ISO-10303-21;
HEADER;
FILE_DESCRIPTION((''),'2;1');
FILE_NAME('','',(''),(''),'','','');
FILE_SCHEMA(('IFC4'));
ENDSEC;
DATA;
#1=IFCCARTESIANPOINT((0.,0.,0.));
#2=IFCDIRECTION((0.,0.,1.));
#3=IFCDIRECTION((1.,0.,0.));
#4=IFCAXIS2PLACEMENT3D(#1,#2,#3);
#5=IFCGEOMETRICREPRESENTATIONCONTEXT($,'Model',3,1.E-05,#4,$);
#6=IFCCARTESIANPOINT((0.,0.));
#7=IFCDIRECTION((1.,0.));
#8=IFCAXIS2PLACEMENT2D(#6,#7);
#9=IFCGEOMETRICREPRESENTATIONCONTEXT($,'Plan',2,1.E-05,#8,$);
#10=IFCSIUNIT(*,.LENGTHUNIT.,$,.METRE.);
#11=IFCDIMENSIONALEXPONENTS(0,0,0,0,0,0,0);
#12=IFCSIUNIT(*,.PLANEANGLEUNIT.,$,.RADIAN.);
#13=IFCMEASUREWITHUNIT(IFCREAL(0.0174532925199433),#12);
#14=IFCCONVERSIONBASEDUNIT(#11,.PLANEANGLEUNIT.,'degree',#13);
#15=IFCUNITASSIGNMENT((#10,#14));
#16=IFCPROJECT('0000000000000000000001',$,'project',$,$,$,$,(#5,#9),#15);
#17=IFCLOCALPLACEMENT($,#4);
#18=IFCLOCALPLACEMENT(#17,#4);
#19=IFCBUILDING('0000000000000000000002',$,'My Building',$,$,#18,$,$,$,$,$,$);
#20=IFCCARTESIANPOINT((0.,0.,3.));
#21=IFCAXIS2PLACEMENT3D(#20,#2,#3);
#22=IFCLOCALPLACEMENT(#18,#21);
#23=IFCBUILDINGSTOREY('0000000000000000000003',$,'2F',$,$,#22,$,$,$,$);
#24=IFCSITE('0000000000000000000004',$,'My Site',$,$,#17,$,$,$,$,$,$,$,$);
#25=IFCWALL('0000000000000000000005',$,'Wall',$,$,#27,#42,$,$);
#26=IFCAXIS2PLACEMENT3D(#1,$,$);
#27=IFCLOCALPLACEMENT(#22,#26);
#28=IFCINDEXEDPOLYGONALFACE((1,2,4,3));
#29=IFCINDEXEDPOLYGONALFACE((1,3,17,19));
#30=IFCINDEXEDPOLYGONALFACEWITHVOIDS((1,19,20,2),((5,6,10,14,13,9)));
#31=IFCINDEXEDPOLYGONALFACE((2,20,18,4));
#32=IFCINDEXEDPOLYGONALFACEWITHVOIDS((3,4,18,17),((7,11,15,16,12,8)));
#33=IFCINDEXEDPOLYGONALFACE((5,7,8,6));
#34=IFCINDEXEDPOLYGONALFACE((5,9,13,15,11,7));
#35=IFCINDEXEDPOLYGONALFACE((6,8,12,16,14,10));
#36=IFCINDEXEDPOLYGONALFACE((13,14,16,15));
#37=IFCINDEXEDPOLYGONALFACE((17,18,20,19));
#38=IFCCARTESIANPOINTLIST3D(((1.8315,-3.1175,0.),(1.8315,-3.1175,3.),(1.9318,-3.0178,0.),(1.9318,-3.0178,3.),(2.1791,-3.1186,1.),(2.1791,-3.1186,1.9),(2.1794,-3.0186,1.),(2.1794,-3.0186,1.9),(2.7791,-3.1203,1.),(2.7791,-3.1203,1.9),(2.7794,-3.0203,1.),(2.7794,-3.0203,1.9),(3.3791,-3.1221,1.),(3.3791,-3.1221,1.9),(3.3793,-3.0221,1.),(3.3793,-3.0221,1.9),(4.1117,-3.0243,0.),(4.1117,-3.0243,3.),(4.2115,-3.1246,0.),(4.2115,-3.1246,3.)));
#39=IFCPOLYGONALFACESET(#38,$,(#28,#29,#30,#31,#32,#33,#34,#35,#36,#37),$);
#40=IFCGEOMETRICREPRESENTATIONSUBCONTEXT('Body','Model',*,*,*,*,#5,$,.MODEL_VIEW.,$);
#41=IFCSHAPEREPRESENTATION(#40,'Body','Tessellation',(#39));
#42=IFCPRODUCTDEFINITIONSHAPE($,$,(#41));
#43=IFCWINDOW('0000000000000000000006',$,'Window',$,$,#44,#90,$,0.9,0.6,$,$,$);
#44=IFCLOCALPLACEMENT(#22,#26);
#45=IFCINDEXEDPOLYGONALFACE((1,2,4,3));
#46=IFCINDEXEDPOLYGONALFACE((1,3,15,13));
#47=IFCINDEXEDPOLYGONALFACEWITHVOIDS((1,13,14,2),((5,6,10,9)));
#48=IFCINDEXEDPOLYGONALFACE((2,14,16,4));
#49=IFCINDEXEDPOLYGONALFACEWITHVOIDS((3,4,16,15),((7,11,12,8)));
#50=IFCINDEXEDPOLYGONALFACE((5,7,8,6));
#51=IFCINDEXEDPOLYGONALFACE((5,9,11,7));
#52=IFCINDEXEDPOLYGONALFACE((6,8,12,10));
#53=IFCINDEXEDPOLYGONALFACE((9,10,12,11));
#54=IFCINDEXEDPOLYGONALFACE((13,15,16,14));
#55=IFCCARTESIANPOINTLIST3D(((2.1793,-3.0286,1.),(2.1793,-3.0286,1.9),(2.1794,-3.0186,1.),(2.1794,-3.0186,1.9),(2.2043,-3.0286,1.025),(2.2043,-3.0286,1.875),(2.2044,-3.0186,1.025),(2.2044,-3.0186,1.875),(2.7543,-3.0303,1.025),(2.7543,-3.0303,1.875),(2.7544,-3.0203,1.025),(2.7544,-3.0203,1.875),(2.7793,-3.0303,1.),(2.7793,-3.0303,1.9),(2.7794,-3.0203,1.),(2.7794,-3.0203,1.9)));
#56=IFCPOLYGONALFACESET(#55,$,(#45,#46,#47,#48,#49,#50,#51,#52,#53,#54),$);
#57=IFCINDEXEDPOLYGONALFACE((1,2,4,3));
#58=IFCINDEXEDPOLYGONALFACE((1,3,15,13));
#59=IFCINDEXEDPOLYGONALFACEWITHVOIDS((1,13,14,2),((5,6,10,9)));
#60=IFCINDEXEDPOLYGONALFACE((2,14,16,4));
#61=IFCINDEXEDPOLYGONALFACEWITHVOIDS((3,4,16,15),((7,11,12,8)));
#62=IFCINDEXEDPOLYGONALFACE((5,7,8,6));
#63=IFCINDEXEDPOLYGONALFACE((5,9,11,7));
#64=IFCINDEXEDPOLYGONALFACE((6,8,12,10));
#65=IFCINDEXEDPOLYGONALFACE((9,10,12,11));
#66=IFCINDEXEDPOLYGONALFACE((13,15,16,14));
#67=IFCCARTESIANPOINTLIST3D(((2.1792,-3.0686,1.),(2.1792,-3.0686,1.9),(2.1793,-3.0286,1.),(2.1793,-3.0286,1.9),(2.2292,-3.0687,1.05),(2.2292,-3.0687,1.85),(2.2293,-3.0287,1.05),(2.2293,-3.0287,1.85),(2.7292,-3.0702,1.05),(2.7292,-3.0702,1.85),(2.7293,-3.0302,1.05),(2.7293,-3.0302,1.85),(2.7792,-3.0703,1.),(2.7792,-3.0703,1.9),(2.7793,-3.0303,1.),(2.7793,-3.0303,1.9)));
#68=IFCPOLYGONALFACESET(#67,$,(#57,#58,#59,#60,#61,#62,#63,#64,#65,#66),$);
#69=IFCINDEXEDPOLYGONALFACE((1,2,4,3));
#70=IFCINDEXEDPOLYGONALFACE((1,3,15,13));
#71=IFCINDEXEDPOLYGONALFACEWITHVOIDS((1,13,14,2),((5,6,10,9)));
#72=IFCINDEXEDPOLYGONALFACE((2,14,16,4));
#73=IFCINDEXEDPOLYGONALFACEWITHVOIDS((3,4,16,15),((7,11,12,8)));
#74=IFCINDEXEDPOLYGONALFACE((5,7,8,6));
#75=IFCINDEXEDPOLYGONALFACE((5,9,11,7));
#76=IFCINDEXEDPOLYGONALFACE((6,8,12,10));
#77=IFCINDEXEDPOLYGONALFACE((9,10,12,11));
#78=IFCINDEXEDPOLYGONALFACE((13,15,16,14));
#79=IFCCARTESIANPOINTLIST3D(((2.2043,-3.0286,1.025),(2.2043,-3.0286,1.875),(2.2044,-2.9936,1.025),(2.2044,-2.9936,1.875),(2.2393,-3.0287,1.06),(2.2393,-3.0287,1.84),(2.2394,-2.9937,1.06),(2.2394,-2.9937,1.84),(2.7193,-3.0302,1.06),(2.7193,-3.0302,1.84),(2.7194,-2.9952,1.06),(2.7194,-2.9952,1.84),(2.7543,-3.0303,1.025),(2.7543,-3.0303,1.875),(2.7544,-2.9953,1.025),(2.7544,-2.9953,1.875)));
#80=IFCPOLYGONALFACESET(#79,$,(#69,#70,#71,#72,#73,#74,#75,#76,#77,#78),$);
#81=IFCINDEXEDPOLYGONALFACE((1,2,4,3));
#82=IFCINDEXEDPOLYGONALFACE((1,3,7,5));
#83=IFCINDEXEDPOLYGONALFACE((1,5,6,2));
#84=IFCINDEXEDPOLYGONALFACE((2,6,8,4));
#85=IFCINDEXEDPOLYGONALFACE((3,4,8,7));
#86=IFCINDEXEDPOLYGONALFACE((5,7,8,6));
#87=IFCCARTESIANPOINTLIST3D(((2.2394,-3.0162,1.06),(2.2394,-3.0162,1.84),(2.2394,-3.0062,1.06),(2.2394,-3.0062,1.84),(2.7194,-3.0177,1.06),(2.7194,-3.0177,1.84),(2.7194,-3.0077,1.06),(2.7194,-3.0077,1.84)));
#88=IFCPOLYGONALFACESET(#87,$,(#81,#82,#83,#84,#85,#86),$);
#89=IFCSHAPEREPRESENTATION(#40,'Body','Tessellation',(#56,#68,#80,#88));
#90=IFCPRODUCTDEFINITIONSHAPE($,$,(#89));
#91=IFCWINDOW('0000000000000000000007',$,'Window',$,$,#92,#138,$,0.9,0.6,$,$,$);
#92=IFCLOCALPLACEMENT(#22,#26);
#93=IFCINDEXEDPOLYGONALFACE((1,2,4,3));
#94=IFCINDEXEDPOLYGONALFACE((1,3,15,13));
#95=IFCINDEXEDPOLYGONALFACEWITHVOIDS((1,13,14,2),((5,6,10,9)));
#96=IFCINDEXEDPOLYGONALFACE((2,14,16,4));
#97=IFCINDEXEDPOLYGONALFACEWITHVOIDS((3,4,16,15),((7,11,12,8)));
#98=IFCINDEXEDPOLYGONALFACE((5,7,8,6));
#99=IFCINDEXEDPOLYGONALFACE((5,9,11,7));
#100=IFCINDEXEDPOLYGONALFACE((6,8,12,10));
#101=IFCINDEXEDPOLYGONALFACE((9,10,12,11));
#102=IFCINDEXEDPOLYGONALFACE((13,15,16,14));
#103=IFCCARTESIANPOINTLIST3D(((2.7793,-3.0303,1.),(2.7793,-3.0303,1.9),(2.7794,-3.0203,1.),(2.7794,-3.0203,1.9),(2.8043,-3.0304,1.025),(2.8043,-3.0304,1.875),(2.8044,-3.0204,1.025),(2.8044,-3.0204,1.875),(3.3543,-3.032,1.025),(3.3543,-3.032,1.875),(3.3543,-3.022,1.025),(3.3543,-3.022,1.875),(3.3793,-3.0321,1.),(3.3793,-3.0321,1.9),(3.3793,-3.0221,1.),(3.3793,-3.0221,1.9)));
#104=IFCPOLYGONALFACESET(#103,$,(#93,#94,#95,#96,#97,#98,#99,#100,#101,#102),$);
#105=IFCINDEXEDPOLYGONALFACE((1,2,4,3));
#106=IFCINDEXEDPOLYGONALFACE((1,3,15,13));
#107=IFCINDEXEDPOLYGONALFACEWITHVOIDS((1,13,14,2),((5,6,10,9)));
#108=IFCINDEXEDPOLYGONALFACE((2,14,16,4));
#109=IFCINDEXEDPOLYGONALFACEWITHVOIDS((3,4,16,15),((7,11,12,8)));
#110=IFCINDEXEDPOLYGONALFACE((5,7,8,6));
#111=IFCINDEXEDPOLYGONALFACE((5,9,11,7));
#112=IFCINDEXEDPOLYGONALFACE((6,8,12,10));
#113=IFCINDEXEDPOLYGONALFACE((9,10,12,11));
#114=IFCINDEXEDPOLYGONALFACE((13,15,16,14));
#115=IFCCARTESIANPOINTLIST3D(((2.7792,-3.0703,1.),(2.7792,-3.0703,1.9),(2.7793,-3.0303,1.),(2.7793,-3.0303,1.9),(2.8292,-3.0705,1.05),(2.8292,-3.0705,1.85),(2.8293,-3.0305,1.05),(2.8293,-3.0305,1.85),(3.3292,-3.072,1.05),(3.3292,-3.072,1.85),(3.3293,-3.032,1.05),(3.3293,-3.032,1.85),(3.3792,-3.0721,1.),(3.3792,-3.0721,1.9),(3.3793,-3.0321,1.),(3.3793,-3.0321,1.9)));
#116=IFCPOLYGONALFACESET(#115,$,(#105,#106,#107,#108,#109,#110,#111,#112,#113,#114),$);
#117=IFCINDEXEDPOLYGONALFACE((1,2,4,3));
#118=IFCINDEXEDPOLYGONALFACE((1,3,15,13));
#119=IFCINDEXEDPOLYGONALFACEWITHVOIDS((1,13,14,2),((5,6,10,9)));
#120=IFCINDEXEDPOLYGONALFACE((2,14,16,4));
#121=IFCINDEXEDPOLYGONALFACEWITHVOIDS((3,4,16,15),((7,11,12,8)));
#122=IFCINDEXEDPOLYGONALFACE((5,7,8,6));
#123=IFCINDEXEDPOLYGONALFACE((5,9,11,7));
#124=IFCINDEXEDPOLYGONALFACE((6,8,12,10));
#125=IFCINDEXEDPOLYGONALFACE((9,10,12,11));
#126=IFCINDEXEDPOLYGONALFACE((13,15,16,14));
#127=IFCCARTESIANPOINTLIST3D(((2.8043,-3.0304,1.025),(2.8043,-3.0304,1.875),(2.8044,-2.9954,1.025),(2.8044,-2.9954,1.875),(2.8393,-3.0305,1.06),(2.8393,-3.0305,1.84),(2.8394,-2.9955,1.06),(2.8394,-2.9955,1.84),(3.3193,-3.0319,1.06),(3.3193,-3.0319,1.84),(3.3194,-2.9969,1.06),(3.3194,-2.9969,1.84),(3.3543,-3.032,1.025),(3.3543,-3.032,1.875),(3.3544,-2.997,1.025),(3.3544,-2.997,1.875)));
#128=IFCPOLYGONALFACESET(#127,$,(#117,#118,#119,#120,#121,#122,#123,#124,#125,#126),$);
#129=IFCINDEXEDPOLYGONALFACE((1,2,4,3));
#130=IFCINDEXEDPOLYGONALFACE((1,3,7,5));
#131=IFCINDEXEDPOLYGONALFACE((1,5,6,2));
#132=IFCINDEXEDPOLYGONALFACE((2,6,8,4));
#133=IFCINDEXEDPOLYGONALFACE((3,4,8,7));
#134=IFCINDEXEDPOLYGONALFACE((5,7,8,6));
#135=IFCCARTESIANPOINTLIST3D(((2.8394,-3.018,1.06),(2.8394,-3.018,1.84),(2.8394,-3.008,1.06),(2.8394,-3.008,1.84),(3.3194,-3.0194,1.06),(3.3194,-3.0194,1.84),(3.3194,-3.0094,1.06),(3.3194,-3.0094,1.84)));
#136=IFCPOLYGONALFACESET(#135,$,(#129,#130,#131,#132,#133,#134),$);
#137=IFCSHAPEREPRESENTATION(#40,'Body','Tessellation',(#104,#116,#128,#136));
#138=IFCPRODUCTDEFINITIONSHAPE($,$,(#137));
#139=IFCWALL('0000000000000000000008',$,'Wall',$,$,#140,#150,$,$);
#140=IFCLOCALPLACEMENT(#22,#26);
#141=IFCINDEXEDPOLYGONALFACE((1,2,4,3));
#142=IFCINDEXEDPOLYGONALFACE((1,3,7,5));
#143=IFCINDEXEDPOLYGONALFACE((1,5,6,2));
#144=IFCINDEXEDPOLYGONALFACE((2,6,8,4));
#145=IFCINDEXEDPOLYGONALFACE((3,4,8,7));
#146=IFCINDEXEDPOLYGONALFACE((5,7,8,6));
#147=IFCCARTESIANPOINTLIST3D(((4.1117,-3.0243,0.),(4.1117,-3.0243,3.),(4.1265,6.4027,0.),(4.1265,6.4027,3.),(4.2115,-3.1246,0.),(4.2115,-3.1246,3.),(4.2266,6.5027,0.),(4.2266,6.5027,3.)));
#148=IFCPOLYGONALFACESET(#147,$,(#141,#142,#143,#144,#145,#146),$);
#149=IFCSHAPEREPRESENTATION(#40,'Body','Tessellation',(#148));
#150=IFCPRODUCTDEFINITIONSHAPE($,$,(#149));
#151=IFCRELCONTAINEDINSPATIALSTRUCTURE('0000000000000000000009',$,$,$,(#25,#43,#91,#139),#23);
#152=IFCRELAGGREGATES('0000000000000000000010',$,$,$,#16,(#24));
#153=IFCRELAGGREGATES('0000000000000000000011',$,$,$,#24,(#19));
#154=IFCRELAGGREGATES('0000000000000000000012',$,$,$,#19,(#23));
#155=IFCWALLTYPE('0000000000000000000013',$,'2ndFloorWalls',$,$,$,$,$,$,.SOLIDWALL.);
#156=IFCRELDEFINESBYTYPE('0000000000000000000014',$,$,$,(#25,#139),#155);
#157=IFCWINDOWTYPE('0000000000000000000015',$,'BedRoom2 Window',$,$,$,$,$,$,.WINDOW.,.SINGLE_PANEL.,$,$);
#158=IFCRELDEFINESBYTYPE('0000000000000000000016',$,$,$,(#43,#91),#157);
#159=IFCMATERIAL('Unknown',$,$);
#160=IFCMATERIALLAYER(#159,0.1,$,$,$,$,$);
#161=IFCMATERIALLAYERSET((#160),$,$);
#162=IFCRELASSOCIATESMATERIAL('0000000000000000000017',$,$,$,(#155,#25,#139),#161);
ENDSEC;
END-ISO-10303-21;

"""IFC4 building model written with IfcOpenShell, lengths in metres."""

from ifc_helpers import new_model, entity, si_unit, converted_unit, frame, origin_with_axes, origin_2d_with_axis, place, context, subcontext, project, spatial, line, indexed_curve, outline, extrude, shape, source, transform, mapped, material, layer, layer_set, layer_usage, type_object, type_shapes, element, fill, save


model = new_model("IFC4")

# Units and contexts
model_context = context("Model", 3, precision=1e-05, world=origin_with_axes())
plan_context = context("Plan", 2, precision=1e-05, world=origin_2d_with_axis())
body_context_1 = subcontext(model_context, "Body", "Model", "MODEL_VIEW")
body_context_2 = subcontext(plan_context, "Body", "Plan", "PLAN_VIEW")
ifc_project = project(units=[si_unit("LENGTHUNIT", "METRE"), converted_unit("PLANEANGLEUNIT", "degree", entity("IfcReal", 0.0174532925199433), si_unit("PLANEANGLEUNIT", "RADIAN"), dimensions=[0, 0, 0, 0, 0, 0, 0])], contexts=[model_context, plan_context])

# Site, building, storey
site_placement = place(None, origin_with_axes())
site = spatial("IfcSite", under=ifc_project, at=site_placement, Name="My Site")
building_placement = place(site_placement, origin_with_axes())
building = spatial("IfcBuilding", under=site, at=building_placement, Name="My Building")
storey_placement = place(building_placement, frame((0.0, 0.0, 3.0), z_axis=(0.0, 0.0, 1.0), x_axis=(1.0, 0.0, 0.0)))
storey = spatial("IfcBuildingStorey", under=building, at=storey_placement, Name="2F")

# Shared definitions
ifc_material = material(Name="Unknown")

# Shared definitions
ifc_layer = layer(ifc_material, 0.1)
ifc_layer_set = layer_set([ifc_layer])
wall_type = type_object("IfcWallType", Name="2ndFloorWalls", PredefinedType="SOLIDWALL", material=ifc_layer_set)

# Wall, openings, windows
ifc_layer_usage_1 = layer_usage(ifc_layer_set, "AXIS2", "POSITIVE", 0.0)
wall_1_placement = place(storey_placement, frame((1.8315, -3.1175, 0.0), z_axis=(0.0, 0.0, 1.0), x_axis=(0.999996, -0.002968, 0.0)))
wall_1 = element("IfcWall", 1, at=wall_1_placement, inside=storey, type_object=wall_type, material=ifc_layer_usage_1, Name="Wall", context=body_context_1, shape_type="SweptSolid", body=[
    extrude(outline(indexed_curve([(0.0, 0.0), (0.1, 0.1), (2.2799, 0.1), (2.38, 0.0)], segments=[line(1, 2, 3, 4, 1)])), origin_with_axes(), (0.0, 0.0, 1.0), 3.0),
])
shared_shape_1 = source(origin_with_axes(), body_context_1, "Body", "SweptSolid", [
    extrude(outline(indexed_curve([(0.0, 0.0), (0.6, 0.0), (0.6, 0.9), (0.0, 0.9)], segments=[line(1, 2, 3, 4, 1)])), frame((0.0, -0.6, 0.0), z_axis=(0.0, -1.0, 0.0), x_axis=(1.0, 0.0, 0.0)), (0.0, 0.0, -1.0), 1.2),
])
opening_1_placement = place(wall_1_placement, frame((0.3476, 0.0, 1.0), z_axis=(0.0, 0.0, 1.0), x_axis=(1.0, 0.0, 0.0)))
opening_1 = element("IfcOpeningElement", 2, at=opening_1_placement, cuts=wall_1, PredefinedType="OPENING", context=body_context_1, shape_type="MappedRepresentation", body=[
    mapped(shared_shape_1, transform((0.0, 0.0, 0.0), x_axis=(1.0, 0.0, 0.0), y_axis=(0.0, 1.0, 0.0), z_axis=(0.0, 0.0, 1.0), scale=1.0)),
])
opening_2_placement = place(wall_1_placement, frame((0.9476, 0.0, 1.0), z_axis=(0.0, 0.0, 1.0), x_axis=(1.0, 0.0, 0.0)))
opening_2 = element("IfcOpeningElement", 3, at=opening_2_placement, cuts=wall_1, PredefinedType="OPENING", context=body_context_1, shape_type="MappedRepresentation", body=[
    mapped(shared_shape_1, transform((0.0, 0.0, 0.0), x_axis=(1.0, 0.0, 0.0), y_axis=(0.0, 1.0, 0.0), z_axis=(0.0, 0.0, 1.0), scale=1.0)),
])
window_type = type_object("IfcWindowType", Name="BedRoom2 Window", PartitioningType="SINGLE_PANEL", PredefinedType="WINDOW")
shared_shape_2 = source(origin_with_axes(), body_context_1, "Body", "SweptSolid", [
    extrude(outline(indexed_curve([(0.0, 0.0), (0.6, 0.0), (0.6, 0.9), (0.0, 0.9)], segments=[line(1, 2, 3, 4, 1)]), holes=[indexed_curve([(0.025, 0.025), (0.575, 0.025), (0.575, 0.875), (0.025, 0.875)], segments=[line(1, 2, 3, 4, 1)])]), frame((0.0, 0.09, 0.0), z_axis=(0.0, -1.0, 0.0), x_axis=(1.0, 0.0, 0.0)), (0.0, 0.0, -1.0), 0.01),
    extrude(outline(indexed_curve([(0.0, 0.0), (0.6, 0.0), (0.6, 0.9), (0.0, 0.9)], segments=[line(1, 2, 3, 4, 1)]), holes=[indexed_curve([(0.05, 0.05), (0.55, 0.05), (0.55, 0.85), (0.05, 0.85)], segments=[line(1, 2, 3, 4, 1)])]), frame((0.0, 0.05, 0.0), z_axis=(0.0, -1.0, 0.0), x_axis=(1.0, 0.0, 0.0)), (0.0, 0.0, -1.0), 0.04),
    extrude(outline(indexed_curve([(0.0, 0.0), (0.55, 0.0), (0.55, 0.85), (0.0, 0.85)], segments=[line(1, 2, 3, 4, 1)]), holes=[indexed_curve([(0.035, 0.035), (0.515, 0.035), (0.515, 0.815), (0.035, 0.815)], segments=[line(1, 2, 3, 4, 1)])]), frame((0.025, 0.09, 0.025), z_axis=(0.0, -1.0, 0.0), x_axis=(1.0, 0.0, 0.0)), (0.0, 0.0, -1.0), 0.035),
    extrude(outline(indexed_curve([(0.035, 0.035), (0.515, 0.035), (0.515, 0.815), (0.035, 0.815)], segments=[line(1, 2, 3, 4, 1)])), frame((0.025, 0.1025, 0.025), z_axis=(0.0, -1.0, 0.0), x_axis=(1.0, 0.0, 0.0)), (0.0, 0.0, -1.0), 0.01),
])
shared_shape_3 = source(origin_with_axes(), body_context_2, "Body", "Curve2D", [
    entity("IfcIndexedPolyCurve", entity("IfcCartesianPointList2D", [[0.05, 0.05], [0.55, 0.05]])),
    entity("IfcIndexedPolyCurve", entity("IfcCartesianPointList2D", [[0.0, 0.1], [0.025, 0.1], [0.025, 0.09], [0.05, 0.09], [0.05, 0.05], [0.0, 0.05]]), [entity("IfcLineIndex", [1, 2, 3, 4, 5, 6, 1])]),
    entity("IfcIndexedPolyCurve", entity("IfcCartesianPointList2D", [[0.6, 0.1], [0.575, 0.1], [0.575, 0.09], [0.55, 0.09], [0.55, 0.05], [0.6, 0.05]]), [entity("IfcLineIndex", [1, 2, 3, 4, 5, 6, 1])]),
    entity("IfcIndexedPolyCurve", entity("IfcCartesianPointList2D", [[0.025, 0.09], [0.06, 0.09], [0.06, 0.125], [0.025, 0.125]]), [entity("IfcLineIndex", [1, 2, 3, 4, 1])]),
    entity("IfcIndexedPolyCurve", entity("IfcCartesianPointList2D", [[0.575, 0.09], [0.54, 0.09], [0.54, 0.125], [0.575, 0.125]]), [entity("IfcLineIndex", [1, 2, 3, 4, 1])]),
    entity("IfcIndexedPolyCurve", entity("IfcCartesianPointList2D", [[0.06, 0.09], [0.54, 0.09]])),
    entity("IfcIndexedPolyCurve", entity("IfcCartesianPointList2D", [[0.06, 0.125], [0.54, 0.125]])),
    entity("IfcIndexedPolyCurve", entity("IfcCartesianPointList2D", [[0.06, 0.1075], [0.54, 0.1075]])),
])
type_shapes(window_type, [shared_shape_2, shared_shape_3])
window_1_placement = place(opening_1_placement, origin_with_axes())
window_1 = element("IfcWindow", 4, at=window_1_placement, inside=storey, type_object=window_type, Name="Window", OverallHeight=0.9, OverallWidth=0.6, shapes=[
    shape(body_context_1, "Body", "MappedRepresentation", [mapped(shared_shape_2, transform((0.0, 0.0, 0.0), x_axis=(1.0, 0.0, 0.0), y_axis=(0.0, 1.0, 0.0), z_axis=(0.0, 0.0, 1.0), scale=1.0))]),
    shape(body_context_2, "Body", "MappedRepresentation", [mapped(shared_shape_3, transform((0.0, 0.0, 0.0), x_axis=(1.0, 0.0, 0.0), y_axis=(0.0, 1.0, 0.0), z_axis=(0.0, 0.0, 1.0), scale=1.0))]),
])
fill(opening_1, window_1)
window_2_placement = place(opening_2_placement, frame((0.0, 0.0, 0.0), z_axis=(0.0, 0.0, 1.0), x_axis=(1.0, 0.0, 0.0)))
window_2 = element("IfcWindow", 5, at=window_2_placement, inside=storey, type_object=window_type, Name="Window", OverallHeight=0.9, OverallWidth=0.6, shapes=[
    shape(body_context_1, "Body", "MappedRepresentation", [mapped(shared_shape_2, transform((0.0, 0.0, 0.0), x_axis=(1.0, 0.0, 0.0), y_axis=(0.0, 1.0, 0.0), z_axis=(0.0, 0.0, 1.0), scale=1.0))]),
    shape(body_context_2, "Body", "MappedRepresentation", [mapped(shared_shape_3, transform((0.0, 0.0, 0.0), x_axis=(1.0, 0.0, 0.0), y_axis=(0.0, 1.0, 0.0), z_axis=(0.0, 0.0, 1.0), scale=1.0))]),
])
fill(opening_2, window_2)

# Wall
ifc_layer_usage_2 = layer_usage(ifc_layer_set, "AXIS2", "POSITIVE", 0.0)
wall_2_placement = place(storey_placement, frame((4.2115, -3.1246, 0.0), z_axis=(0.0, 0.0, 1.0), x_axis=(0.00157, 0.999999, 0.0)))
element("IfcWall", 6, at=wall_2_placement, inside=storey, type_object=wall_type, material=ifc_layer_usage_2, Name="Wall", context=body_context_1, shape_type="SweptSolid", body=[
    extrude(outline(indexed_curve([(0.0, 0.0), (0.1001, 0.1), (9.5272, 0.1), (9.6273, 0.0)], segments=[line(1, 2, 3, 4, 1)])), origin_with_axes(), (0.0, 0.0, 1.0), 3.0),
])

save(model, "model.ifc")
